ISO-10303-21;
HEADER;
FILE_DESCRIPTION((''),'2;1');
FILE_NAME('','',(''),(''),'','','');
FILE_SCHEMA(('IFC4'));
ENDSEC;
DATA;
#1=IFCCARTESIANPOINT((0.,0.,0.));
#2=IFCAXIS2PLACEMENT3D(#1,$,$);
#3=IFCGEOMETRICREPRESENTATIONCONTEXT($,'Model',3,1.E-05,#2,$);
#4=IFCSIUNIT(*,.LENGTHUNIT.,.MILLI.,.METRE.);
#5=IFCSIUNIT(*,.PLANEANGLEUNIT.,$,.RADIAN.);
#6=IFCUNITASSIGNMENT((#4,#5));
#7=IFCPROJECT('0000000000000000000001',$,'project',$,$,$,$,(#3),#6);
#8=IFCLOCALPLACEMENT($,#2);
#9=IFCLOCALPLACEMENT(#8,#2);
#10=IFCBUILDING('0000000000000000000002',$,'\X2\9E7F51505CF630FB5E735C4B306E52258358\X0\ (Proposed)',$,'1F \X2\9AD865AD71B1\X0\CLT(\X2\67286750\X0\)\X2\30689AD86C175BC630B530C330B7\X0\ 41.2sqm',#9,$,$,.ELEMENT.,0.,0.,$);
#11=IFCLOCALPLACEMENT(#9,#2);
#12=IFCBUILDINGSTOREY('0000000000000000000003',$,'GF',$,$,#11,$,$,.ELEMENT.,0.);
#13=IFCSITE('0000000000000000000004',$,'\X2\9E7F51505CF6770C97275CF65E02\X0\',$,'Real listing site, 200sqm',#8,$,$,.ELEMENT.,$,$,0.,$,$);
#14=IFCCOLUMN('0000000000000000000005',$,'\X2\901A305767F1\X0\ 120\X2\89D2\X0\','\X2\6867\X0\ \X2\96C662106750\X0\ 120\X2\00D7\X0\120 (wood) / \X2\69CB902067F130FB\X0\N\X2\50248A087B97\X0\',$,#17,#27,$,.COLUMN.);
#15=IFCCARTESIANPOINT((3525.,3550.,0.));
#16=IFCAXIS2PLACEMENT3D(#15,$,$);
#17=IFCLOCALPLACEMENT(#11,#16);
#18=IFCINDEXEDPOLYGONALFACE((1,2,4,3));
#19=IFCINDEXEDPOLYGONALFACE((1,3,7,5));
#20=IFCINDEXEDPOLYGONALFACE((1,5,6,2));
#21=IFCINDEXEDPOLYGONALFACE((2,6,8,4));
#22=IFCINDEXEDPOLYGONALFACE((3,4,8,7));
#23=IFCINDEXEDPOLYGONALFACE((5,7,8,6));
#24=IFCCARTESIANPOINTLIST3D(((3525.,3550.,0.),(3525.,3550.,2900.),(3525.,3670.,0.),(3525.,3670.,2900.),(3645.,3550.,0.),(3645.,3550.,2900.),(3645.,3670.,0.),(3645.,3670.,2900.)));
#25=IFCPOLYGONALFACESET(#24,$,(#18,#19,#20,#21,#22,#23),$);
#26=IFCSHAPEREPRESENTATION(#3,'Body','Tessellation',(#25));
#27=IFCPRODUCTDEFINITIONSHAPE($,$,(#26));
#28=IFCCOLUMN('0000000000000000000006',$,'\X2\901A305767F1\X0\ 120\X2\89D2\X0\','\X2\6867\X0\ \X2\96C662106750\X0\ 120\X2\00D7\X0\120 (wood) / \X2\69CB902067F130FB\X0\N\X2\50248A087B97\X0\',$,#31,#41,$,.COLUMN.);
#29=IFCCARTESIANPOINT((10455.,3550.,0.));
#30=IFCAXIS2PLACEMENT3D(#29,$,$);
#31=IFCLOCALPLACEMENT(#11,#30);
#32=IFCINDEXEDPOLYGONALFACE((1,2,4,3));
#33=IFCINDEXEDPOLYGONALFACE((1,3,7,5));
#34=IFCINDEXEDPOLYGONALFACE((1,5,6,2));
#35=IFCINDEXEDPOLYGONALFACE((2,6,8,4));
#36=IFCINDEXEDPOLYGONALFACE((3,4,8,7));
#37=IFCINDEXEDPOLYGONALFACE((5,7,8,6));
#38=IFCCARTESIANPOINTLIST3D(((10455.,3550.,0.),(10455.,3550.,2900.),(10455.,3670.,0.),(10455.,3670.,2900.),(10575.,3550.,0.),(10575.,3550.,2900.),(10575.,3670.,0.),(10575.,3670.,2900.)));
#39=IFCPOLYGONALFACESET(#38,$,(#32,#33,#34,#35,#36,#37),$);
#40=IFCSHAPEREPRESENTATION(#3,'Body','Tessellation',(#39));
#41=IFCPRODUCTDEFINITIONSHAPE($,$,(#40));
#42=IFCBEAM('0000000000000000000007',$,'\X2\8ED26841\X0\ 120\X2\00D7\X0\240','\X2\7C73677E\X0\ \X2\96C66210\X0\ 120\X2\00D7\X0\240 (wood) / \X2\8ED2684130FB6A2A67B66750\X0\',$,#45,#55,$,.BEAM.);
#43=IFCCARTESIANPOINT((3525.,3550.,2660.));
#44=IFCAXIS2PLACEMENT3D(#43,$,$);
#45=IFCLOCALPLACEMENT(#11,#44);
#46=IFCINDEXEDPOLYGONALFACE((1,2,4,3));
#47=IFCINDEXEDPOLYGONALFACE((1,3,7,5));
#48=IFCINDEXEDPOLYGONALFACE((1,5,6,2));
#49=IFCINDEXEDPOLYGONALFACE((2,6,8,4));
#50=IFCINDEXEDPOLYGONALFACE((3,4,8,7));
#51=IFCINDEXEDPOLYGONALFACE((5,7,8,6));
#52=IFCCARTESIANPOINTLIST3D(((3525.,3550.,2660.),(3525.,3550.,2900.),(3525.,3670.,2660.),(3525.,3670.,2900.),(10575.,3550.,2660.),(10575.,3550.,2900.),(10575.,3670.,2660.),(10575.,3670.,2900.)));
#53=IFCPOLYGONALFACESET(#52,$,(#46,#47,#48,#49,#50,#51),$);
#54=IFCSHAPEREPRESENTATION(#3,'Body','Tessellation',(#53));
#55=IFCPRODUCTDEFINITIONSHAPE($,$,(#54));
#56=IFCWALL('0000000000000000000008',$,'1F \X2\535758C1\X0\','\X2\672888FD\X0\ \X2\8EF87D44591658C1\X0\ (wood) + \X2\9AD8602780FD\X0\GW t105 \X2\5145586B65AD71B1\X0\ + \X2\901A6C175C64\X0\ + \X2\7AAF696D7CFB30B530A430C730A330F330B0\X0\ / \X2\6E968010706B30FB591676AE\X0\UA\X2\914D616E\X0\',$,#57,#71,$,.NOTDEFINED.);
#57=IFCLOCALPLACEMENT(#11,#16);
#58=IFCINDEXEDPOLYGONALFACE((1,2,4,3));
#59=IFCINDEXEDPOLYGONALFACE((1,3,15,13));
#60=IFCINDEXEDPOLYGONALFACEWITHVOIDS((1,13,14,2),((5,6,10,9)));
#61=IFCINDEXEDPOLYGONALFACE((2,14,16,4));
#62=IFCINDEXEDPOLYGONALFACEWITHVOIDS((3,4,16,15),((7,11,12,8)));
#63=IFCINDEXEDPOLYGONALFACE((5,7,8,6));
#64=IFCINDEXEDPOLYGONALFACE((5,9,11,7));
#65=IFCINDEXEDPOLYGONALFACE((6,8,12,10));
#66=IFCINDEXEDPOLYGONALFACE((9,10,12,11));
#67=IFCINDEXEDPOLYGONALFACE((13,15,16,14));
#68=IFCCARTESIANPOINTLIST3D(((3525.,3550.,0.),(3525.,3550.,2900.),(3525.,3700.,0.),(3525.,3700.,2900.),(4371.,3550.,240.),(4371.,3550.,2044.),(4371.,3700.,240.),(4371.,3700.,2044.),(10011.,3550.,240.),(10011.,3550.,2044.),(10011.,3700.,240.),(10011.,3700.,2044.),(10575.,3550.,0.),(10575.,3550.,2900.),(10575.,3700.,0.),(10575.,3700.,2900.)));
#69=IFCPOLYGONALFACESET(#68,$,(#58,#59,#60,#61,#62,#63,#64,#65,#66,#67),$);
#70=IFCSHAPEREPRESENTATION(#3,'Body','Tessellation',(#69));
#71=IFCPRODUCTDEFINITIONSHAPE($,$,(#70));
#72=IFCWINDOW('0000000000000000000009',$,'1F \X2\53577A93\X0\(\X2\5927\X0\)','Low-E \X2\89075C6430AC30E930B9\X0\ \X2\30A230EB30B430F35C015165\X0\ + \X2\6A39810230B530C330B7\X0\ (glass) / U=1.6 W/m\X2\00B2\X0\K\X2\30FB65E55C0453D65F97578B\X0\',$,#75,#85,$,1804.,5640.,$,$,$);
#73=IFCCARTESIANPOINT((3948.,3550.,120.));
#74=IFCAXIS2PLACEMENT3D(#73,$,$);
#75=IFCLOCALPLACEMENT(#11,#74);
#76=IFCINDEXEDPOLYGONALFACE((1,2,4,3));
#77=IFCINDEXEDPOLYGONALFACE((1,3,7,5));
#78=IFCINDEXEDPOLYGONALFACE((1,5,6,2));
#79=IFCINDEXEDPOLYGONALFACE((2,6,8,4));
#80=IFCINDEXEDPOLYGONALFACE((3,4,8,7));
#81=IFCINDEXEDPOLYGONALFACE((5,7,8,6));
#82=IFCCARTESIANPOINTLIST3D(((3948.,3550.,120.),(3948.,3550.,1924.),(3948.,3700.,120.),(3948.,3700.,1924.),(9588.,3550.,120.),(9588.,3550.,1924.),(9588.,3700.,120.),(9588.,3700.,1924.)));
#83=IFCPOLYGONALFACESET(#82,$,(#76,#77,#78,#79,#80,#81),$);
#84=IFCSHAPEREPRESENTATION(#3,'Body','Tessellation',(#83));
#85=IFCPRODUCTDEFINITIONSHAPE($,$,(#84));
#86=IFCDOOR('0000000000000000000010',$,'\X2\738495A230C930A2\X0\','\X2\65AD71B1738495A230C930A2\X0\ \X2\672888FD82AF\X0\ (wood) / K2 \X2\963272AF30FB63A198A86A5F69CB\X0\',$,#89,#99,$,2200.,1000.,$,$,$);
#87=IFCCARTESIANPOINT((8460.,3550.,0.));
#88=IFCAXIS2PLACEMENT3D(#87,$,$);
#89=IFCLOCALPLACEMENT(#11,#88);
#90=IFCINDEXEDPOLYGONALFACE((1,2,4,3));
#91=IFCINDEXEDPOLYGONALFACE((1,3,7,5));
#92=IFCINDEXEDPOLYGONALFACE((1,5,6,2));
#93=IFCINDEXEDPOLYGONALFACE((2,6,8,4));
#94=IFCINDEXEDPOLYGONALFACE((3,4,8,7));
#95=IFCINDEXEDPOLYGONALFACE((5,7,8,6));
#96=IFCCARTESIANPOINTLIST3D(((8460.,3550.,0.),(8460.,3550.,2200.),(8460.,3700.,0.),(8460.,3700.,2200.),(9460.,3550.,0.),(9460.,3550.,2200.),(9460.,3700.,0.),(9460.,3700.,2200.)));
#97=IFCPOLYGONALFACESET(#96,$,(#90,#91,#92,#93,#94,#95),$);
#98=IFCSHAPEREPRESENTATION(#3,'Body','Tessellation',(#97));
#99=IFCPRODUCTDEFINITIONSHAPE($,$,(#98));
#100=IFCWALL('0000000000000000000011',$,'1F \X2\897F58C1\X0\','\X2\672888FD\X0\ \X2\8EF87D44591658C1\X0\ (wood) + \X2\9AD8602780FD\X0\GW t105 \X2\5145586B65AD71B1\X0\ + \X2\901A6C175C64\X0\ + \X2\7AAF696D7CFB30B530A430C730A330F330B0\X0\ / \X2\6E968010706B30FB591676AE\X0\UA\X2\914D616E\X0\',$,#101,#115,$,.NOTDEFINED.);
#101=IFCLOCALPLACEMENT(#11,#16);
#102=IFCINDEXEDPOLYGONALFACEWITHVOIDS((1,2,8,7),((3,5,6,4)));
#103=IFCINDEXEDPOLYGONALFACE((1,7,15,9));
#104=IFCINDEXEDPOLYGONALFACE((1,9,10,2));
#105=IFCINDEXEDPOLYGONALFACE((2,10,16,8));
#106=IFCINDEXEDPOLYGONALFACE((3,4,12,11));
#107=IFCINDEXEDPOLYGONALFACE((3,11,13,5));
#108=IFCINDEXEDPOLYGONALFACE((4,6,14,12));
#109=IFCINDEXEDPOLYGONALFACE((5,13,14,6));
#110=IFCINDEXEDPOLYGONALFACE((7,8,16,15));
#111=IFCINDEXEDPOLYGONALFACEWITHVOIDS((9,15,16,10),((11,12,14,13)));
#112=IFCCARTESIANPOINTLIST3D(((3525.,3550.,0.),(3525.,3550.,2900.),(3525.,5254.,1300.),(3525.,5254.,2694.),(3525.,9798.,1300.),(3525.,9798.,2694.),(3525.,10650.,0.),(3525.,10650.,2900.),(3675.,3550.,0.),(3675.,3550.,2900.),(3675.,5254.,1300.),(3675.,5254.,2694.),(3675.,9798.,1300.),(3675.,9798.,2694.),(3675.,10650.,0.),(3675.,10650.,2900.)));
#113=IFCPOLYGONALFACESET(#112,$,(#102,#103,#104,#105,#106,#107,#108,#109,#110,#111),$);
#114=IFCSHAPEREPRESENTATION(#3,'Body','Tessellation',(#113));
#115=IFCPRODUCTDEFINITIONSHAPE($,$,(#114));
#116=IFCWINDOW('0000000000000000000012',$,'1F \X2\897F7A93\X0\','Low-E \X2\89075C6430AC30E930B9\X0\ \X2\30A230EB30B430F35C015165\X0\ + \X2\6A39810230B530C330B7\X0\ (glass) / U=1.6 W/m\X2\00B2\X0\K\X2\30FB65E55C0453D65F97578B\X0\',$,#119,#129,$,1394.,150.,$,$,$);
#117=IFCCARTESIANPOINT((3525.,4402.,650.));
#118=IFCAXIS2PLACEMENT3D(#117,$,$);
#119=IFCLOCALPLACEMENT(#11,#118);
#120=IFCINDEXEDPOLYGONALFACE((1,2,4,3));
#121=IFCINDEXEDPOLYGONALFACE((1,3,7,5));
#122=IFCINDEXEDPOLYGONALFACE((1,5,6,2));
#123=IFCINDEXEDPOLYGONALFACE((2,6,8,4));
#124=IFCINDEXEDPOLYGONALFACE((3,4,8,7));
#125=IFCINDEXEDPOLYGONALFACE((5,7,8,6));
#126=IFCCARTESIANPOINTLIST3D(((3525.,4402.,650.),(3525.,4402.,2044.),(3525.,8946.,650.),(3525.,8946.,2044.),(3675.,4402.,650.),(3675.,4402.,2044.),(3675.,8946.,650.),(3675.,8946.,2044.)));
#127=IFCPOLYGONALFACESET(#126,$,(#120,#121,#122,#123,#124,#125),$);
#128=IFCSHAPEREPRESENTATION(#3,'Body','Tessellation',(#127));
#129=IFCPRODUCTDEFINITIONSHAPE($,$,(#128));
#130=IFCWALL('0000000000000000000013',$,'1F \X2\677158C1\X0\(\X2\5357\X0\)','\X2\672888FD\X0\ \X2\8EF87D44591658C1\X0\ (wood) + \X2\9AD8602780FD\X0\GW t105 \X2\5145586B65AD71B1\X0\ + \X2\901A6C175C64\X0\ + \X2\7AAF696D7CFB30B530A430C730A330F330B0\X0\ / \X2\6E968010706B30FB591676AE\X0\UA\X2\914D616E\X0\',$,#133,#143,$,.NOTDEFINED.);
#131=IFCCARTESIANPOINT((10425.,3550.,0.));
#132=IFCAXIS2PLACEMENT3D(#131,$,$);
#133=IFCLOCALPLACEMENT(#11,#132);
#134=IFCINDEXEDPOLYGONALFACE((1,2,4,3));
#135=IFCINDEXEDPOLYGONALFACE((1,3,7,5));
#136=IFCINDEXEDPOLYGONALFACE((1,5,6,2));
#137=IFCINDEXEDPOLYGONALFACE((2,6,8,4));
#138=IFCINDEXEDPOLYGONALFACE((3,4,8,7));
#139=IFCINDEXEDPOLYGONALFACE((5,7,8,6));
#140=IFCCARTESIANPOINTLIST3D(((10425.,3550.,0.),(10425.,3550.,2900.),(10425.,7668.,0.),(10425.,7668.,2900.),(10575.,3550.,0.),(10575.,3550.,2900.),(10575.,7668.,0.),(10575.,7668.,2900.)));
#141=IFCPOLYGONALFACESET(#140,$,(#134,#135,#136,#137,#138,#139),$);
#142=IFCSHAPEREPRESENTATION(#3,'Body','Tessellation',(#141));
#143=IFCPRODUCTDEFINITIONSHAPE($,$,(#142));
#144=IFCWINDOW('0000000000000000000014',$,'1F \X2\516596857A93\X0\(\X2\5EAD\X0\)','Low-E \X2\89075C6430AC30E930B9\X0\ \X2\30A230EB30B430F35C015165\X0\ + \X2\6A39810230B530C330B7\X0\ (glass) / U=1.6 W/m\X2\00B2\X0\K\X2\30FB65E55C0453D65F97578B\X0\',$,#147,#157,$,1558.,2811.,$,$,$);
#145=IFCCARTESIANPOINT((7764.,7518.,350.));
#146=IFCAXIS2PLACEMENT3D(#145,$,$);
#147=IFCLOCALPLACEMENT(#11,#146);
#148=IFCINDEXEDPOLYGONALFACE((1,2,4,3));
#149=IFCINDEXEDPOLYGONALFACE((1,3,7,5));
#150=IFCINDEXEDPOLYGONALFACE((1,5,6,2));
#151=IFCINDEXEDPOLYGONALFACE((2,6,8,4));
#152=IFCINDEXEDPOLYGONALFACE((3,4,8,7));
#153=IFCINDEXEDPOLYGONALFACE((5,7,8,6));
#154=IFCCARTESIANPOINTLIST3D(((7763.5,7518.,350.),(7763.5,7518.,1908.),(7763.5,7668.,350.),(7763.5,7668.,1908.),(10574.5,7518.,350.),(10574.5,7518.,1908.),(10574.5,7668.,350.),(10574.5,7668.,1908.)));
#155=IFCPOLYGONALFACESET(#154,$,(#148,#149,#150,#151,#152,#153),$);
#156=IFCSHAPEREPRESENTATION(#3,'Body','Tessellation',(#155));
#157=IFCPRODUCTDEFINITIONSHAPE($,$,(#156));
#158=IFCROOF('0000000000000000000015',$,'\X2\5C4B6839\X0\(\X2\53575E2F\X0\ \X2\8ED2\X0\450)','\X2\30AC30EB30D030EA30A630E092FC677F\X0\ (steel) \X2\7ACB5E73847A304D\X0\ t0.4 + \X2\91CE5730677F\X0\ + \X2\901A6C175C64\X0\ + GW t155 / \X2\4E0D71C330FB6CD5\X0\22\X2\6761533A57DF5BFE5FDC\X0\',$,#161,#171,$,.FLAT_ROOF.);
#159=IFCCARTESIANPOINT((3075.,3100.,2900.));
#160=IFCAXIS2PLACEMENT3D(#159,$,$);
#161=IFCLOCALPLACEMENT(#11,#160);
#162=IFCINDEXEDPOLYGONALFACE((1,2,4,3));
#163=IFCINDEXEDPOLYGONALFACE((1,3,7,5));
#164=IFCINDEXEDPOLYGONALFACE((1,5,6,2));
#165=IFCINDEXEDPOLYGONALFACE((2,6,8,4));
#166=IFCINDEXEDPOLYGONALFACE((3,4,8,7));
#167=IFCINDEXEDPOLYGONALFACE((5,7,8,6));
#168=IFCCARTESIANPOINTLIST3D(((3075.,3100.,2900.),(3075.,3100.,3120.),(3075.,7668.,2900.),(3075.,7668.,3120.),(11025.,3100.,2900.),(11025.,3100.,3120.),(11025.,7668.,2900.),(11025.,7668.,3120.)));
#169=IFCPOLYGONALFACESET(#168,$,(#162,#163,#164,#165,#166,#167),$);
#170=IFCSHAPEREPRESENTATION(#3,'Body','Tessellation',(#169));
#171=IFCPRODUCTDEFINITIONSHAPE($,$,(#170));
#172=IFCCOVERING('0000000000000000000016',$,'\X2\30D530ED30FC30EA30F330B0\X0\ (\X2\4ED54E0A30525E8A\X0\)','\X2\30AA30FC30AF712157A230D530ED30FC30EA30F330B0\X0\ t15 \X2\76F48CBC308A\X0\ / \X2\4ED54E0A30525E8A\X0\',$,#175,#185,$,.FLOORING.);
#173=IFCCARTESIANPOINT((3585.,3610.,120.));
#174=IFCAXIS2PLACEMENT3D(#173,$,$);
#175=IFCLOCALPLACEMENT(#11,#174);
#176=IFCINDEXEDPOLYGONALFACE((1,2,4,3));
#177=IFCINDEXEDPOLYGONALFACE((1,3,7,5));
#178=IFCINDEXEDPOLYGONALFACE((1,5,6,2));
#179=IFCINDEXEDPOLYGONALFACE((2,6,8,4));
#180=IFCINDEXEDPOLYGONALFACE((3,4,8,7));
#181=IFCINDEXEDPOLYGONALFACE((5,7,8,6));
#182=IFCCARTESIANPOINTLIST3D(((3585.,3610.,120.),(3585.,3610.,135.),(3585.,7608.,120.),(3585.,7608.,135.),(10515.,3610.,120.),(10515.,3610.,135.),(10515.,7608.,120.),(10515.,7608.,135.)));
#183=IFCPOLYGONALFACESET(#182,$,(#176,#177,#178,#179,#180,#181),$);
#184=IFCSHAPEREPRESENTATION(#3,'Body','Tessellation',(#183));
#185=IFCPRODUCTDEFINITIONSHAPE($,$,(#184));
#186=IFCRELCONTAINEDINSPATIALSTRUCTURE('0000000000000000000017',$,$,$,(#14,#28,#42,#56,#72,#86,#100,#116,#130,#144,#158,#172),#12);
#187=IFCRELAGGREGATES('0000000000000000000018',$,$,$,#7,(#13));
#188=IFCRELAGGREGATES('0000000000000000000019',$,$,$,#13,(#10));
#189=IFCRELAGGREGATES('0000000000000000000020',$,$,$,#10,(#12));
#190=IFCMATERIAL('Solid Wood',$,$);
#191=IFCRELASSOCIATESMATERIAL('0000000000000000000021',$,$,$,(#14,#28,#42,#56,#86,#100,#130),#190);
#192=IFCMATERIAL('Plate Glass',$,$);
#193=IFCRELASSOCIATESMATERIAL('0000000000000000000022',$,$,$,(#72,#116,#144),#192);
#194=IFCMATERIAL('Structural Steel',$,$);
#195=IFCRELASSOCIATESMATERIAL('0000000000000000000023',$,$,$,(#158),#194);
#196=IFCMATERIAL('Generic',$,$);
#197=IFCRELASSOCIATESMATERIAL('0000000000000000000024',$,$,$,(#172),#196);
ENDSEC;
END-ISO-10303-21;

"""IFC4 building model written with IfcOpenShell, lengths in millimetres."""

from ifc_helpers import new_model, si_unit, frame, frame_2d, origin, place, context, project, spatial, rectangle, extrude, material, element, fill, save


model = new_model("IFC4")

# Units and contexts
model_context = context("Model", 3, precision=1e-05, world=origin())
ifc_project = project(units=[si_unit("LENGTHUNIT", "METRE", prefix="MILLI"), si_unit("PLANEANGLEUNIT", "RADIAN")], contexts=[model_context])

# Site, building, storey
site_placement = place(None, origin())
site = spatial("IfcSite", under=ifc_project, at=site_placement, Name="鹿児島県霧島市", ObjectType="Real listing site, 200sqm", CompositionType="ELEMENT", RefElevation=0.0)
building_placement = place(site_placement, origin())
building = spatial("IfcBuilding", under=site, at=building_placement, Name="鹿児島・平屋の別荘 (Proposed)", ObjectType="1F 高断熱CLT(木材)と高気密サッシ 41.2sqm", CompositionType="ELEMENT", ElevationOfRefHeight=0.0, ElevationOfTerrain=0.0)
storey_placement = place(building_placement, origin())
storey = spatial("IfcBuildingStorey", under=building, at=storey_placement, Name="GF", CompositionType="ELEMENT", Elevation=0.0)

# Columns
ifc_material_1 = material(Name="Solid Wood")
column_1_placement = place(storey_placement, frame((3525.0, 3550.0, 0.0)))
element("IfcColumn", 1, at=column_1_placement, inside=storey, material=ifc_material_1, Name="通し柱 120角", Description="桧 集成材 120×120 (wood) / 構造柱・N値計算", PredefinedType="COLUMN", context=model_context, shape_type="SweptSolid", body=[
    extrude(rectangle(XDim=120.0, YDim=120.0, at=frame_2d((60.0, 60.0))), frame((3525.0, 3550.0, 0.0)), (0.0, 0.0, 1.0), 2900.0),
])
column_2_placement = place(storey_placement, frame((10455.0, 3550.0, 0.0)))
element("IfcColumn", 2, at=column_2_placement, inside=storey, material=ifc_material_1, Name="通し柱 120角", Description="桧 集成材 120×120 (wood) / 構造柱・N値計算", PredefinedType="COLUMN", context=model_context, shape_type="SweptSolid", body=[
    extrude(rectangle(XDim=120.0, YDim=120.0, at=frame_2d((60.0, 60.0))), frame((10455.0, 3550.0, 0.0)), (0.0, 0.0, 1.0), 2900.0),
])

# Beam
beam_1_placement = place(storey_placement, frame((3525.0, 3550.0, 2660.0)))
element("IfcBeam", 3, at=beam_1_placement, inside=storey, material=ifc_material_1, Name="軒桁 120×240", Description="米松 集成 120×240 (wood) / 軒桁・横架材", PredefinedType="BEAM", context=model_context, shape_type="SweptSolid", body=[
    extrude(rectangle(XDim=7050.0, YDim=120.0, at=frame_2d((3525.0, 60.0))), frame((3525.0, 3550.0, 2660.0)), (0.0, 0.0, 1.0), 240.0),
])

# Wall, openings, window, door
wall_1_placement = place(storey_placement, frame((3525.0, 3550.0, 0.0)))
wall_1 = element("IfcWall", 4, at=wall_1_placement, inside=storey, material=ifc_material_1, Name="1F 南壁", Description="木製 軸組外壁 (wood) + 高性能GW t105 充填断熱 + 通気層 + 窯業系サイディング / 準耐火・外皮UA配慮", PredefinedType="NOTDEFINED", context=model_context, shape_type="SweptSolid", body=[
    extrude(rectangle(XDim=7050.0, YDim=150.0, at=frame_2d((3525.0, 75.0))), frame((3525.0, 3550.0, 0.0)), (0.0, 0.0, 1.0), 2900.0),
])
opening_1_placement = place(storey_placement, frame((3948.0, 3550.0, 120.0)))
opening_1 = element("IfcOpeningElement", 5, at=opening_1_placement, cuts=wall_1, PredefinedType="NOTDEFINED", context=model_context, shape_type="SweptSolid", body=[
    extrude(rectangle(XDim=5640.0, YDim=150.0, at=frame_2d((2820.0, 75.0))), frame((3948.0, 3550.0, 120.0)), (0.0, 0.0, 1.0), 1804.0),
])
opening_2_placement = place(storey_placement, frame((8460.0, 3550.0, 0.0)))
opening_2 = element("IfcOpeningElement", 6, at=opening_2_placement, cuts=wall_1, PredefinedType="NOTDEFINED", context=model_context, shape_type="SweptSolid", body=[
    extrude(rectangle(XDim=1000.0, YDim=150.0, at=frame_2d((500.0, 75.0))), frame((8460.0, 3550.0, 0.0)), (0.0, 0.0, 1.0), 2200.0),
])
ifc_material_2 = material(Name="Plate Glass")
window_1_placement = place(storey_placement, frame((3948.0, 3550.0, 120.0)))
window_1 = element("IfcWindow", 7, at=window_1_placement, inside=storey, material=ifc_material_2, Name="1F 南窓(大)", Description="Low-E 複層ガラス アルゴン封入 + 樹脂サッシ (glass) / U=1.6 W/m²K・日射取得型", OverallHeight=1804.0, OverallWidth=5640.0, context=model_context, shape_type="SweptSolid", body=[
    extrude(rectangle(XDim=5640.0, YDim=150.0, at=frame_2d((2820.0, 75.0))), frame((3948.0, 3550.0, 120.0)), (0.0, 0.0, 1.0), 1804.0),
])
fill(opening_1, window_1)
door_1_placement = place(storey_placement, frame((8460.0, 3550.0, 0.0)))
door_1 = element("IfcDoor", 8, at=door_1_placement, inside=storey, material=ifc_material_1, Name="玄関ドア", Description="断熱玄関ドア 木製芯 (wood) / K2 防犯・採風機構", OverallHeight=2200.0, OverallWidth=1000.0, context=model_context, shape_type="SweptSolid", body=[
    extrude(rectangle(XDim=1000.0, YDim=150.0, at=frame_2d((500.0, 75.0))), frame((8460.0, 3550.0, 0.0)), (0.0, 0.0, 1.0), 2200.0),
])
fill(opening_2, door_1)

# Walls, openings, windows
wall_2_placement = place(storey_placement, frame((3525.0, 3550.0, 0.0)))
wall_2 = element("IfcWall", 9, at=wall_2_placement, inside=storey, material=ifc_material_1, Name="1F 西壁", Description="木製 軸組外壁 (wood) + 高性能GW t105 充填断熱 + 通気層 + 窯業系サイディング / 準耐火・外皮UA配慮", PredefinedType="NOTDEFINED", context=model_context, shape_type="SweptSolid", body=[
    extrude(rectangle(XDim=150.0, YDim=7100.0, at=frame_2d((75.0, 3550.0))), frame((3525.0, 3550.0, 0.0)), (0.0, 0.0, 1.0), 2900.0),
])
opening_3_placement = place(storey_placement, frame((3525.0, 4402.0, 650.0)))
opening_3 = element("IfcOpeningElement", 10, at=opening_3_placement, cuts=wall_2, PredefinedType="NOTDEFINED", context=model_context, shape_type="SweptSolid", body=[
    extrude(rectangle(XDim=150.0, YDim=4544.0, at=frame_2d((75.0, 2272.0))), frame((3525.0, 4402.0, 650.0)), (0.0, 0.0, 1.0), 1394.0),
])
window_2_placement = place(storey_placement, frame((3525.0, 4402.0, 650.0)))
window_2 = element("IfcWindow", 11, at=window_2_placement, inside=storey, material=ifc_material_2, Name="1F 西窓", Description="Low-E 複層ガラス アルゴン封入 + 樹脂サッシ (glass) / U=1.6 W/m²K・日射取得型", OverallHeight=1394.0, OverallWidth=150.0, context=model_context, shape_type="SweptSolid", body=[
    extrude(rectangle(XDim=150.0, YDim=4544.0, at=frame_2d((75.0, 2272.0))), frame((3525.0, 4402.0, 650.0)), (0.0, 0.0, 1.0), 1394.0),
])
fill(opening_3, window_2)
wall_3_placement = place(storey_placement, frame((10425.0, 3550.0, 0.0)))
wall_3 = element("IfcWall", 12, at=wall_3_placement, inside=storey, material=ifc_material_1, Name="1F 東壁(南)", Description="木製 軸組外壁 (wood) + 高性能GW t105 充填断熱 + 通気層 + 窯業系サイディング / 準耐火・外皮UA配慮", PredefinedType="NOTDEFINED", context=model_context, shape_type="SweptSolid", body=[
    extrude(rectangle(XDim=150.0, YDim=4118.0, at=frame_2d((75.0, 2059.0))), frame((10425.0, 3550.0, 0.0)), (0.0, 0.0, 1.0), 2900.0),
])
opening_4_placement = place(storey_placement, frame((7764.0, 7518.0, 350.0)))
opening_4 = element("IfcOpeningElement", 13, at=opening_4_placement, cuts=wall_3, PredefinedType="NOTDEFINED", context=model_context, shape_type="SweptSolid", body=[
    extrude(rectangle(XDim=2811.0, YDim=150.0, at=frame_2d((1405.0, 75.0))), frame((7764.0, 7518.0, 350.0)), (0.0, 0.0, 1.0), 1558.0),
])
window_3_placement = place(storey_placement, frame((7764.0, 7518.0, 350.0)))
window_3 = element("IfcWindow", 14, at=window_3_placement, inside=storey, material=ifc_material_2, Name="1F 入隅窓(庭)", Description="Low-E 複層ガラス アルゴン封入 + 樹脂サッシ (glass) / U=1.6 W/m²K・日射取得型", OverallHeight=1558.0, OverallWidth=2811.0, context=model_context, shape_type="SweptSolid", body=[
    extrude(rectangle(XDim=2811.0, YDim=150.0, at=frame_2d((1405.0, 75.0))), frame((7764.0, 7518.0, 350.0)), (0.0, 0.0, 1.0), 1558.0),
])
fill(opening_4, window_3)

# Roof
ifc_material_3 = material(Name="Structural Steel")
roof_placement = place(storey_placement, frame((3075.0, 3100.0, 2900.0)))
element("IfcRoof", 15, at=roof_placement, inside=storey, material=ifc_material_3, Name="屋根(南帯 軒450)", Description="ガルバリウム鋼板 (steel) 立平葺き t0.4 + 野地板 + 通気層 + GW t155 / 不燃・法22条区域対応", PredefinedType="FLAT_ROOF", context=model_context, shape_type="SweptSolid", body=[
    extrude(rectangle(XDim=7950.0, YDim=4568.0, at=frame_2d((3975.0, 2284.0))), frame((3075.0, 3100.0, 2900.0)), (0.0, 0.0, 1.0), 220.0),
])

# Covering
ifc_material_4 = material(Name="Generic")
covering_1_placement = place(storey_placement, frame((3585.0, 3610.0, 120.0)))
element("IfcCovering", 16, at=covering_1_placement, inside=storey, material=ifc_material_4, Name="フローリング (仕上げ床)", Description="オーク無垢フローリング t15 直貼り / 仕上げ床", PredefinedType="FLOORING", context=model_context, shape_type="SweptSolid", body=[
    extrude(rectangle(XDim=6930.0, YDim=3998.0, at=frame_2d((3465.0, 1999.0))), frame((3585.0, 3610.0, 120.0)), (0.0, 0.0, 1.0), 15.0),
])

save(model, "model.ifc")
